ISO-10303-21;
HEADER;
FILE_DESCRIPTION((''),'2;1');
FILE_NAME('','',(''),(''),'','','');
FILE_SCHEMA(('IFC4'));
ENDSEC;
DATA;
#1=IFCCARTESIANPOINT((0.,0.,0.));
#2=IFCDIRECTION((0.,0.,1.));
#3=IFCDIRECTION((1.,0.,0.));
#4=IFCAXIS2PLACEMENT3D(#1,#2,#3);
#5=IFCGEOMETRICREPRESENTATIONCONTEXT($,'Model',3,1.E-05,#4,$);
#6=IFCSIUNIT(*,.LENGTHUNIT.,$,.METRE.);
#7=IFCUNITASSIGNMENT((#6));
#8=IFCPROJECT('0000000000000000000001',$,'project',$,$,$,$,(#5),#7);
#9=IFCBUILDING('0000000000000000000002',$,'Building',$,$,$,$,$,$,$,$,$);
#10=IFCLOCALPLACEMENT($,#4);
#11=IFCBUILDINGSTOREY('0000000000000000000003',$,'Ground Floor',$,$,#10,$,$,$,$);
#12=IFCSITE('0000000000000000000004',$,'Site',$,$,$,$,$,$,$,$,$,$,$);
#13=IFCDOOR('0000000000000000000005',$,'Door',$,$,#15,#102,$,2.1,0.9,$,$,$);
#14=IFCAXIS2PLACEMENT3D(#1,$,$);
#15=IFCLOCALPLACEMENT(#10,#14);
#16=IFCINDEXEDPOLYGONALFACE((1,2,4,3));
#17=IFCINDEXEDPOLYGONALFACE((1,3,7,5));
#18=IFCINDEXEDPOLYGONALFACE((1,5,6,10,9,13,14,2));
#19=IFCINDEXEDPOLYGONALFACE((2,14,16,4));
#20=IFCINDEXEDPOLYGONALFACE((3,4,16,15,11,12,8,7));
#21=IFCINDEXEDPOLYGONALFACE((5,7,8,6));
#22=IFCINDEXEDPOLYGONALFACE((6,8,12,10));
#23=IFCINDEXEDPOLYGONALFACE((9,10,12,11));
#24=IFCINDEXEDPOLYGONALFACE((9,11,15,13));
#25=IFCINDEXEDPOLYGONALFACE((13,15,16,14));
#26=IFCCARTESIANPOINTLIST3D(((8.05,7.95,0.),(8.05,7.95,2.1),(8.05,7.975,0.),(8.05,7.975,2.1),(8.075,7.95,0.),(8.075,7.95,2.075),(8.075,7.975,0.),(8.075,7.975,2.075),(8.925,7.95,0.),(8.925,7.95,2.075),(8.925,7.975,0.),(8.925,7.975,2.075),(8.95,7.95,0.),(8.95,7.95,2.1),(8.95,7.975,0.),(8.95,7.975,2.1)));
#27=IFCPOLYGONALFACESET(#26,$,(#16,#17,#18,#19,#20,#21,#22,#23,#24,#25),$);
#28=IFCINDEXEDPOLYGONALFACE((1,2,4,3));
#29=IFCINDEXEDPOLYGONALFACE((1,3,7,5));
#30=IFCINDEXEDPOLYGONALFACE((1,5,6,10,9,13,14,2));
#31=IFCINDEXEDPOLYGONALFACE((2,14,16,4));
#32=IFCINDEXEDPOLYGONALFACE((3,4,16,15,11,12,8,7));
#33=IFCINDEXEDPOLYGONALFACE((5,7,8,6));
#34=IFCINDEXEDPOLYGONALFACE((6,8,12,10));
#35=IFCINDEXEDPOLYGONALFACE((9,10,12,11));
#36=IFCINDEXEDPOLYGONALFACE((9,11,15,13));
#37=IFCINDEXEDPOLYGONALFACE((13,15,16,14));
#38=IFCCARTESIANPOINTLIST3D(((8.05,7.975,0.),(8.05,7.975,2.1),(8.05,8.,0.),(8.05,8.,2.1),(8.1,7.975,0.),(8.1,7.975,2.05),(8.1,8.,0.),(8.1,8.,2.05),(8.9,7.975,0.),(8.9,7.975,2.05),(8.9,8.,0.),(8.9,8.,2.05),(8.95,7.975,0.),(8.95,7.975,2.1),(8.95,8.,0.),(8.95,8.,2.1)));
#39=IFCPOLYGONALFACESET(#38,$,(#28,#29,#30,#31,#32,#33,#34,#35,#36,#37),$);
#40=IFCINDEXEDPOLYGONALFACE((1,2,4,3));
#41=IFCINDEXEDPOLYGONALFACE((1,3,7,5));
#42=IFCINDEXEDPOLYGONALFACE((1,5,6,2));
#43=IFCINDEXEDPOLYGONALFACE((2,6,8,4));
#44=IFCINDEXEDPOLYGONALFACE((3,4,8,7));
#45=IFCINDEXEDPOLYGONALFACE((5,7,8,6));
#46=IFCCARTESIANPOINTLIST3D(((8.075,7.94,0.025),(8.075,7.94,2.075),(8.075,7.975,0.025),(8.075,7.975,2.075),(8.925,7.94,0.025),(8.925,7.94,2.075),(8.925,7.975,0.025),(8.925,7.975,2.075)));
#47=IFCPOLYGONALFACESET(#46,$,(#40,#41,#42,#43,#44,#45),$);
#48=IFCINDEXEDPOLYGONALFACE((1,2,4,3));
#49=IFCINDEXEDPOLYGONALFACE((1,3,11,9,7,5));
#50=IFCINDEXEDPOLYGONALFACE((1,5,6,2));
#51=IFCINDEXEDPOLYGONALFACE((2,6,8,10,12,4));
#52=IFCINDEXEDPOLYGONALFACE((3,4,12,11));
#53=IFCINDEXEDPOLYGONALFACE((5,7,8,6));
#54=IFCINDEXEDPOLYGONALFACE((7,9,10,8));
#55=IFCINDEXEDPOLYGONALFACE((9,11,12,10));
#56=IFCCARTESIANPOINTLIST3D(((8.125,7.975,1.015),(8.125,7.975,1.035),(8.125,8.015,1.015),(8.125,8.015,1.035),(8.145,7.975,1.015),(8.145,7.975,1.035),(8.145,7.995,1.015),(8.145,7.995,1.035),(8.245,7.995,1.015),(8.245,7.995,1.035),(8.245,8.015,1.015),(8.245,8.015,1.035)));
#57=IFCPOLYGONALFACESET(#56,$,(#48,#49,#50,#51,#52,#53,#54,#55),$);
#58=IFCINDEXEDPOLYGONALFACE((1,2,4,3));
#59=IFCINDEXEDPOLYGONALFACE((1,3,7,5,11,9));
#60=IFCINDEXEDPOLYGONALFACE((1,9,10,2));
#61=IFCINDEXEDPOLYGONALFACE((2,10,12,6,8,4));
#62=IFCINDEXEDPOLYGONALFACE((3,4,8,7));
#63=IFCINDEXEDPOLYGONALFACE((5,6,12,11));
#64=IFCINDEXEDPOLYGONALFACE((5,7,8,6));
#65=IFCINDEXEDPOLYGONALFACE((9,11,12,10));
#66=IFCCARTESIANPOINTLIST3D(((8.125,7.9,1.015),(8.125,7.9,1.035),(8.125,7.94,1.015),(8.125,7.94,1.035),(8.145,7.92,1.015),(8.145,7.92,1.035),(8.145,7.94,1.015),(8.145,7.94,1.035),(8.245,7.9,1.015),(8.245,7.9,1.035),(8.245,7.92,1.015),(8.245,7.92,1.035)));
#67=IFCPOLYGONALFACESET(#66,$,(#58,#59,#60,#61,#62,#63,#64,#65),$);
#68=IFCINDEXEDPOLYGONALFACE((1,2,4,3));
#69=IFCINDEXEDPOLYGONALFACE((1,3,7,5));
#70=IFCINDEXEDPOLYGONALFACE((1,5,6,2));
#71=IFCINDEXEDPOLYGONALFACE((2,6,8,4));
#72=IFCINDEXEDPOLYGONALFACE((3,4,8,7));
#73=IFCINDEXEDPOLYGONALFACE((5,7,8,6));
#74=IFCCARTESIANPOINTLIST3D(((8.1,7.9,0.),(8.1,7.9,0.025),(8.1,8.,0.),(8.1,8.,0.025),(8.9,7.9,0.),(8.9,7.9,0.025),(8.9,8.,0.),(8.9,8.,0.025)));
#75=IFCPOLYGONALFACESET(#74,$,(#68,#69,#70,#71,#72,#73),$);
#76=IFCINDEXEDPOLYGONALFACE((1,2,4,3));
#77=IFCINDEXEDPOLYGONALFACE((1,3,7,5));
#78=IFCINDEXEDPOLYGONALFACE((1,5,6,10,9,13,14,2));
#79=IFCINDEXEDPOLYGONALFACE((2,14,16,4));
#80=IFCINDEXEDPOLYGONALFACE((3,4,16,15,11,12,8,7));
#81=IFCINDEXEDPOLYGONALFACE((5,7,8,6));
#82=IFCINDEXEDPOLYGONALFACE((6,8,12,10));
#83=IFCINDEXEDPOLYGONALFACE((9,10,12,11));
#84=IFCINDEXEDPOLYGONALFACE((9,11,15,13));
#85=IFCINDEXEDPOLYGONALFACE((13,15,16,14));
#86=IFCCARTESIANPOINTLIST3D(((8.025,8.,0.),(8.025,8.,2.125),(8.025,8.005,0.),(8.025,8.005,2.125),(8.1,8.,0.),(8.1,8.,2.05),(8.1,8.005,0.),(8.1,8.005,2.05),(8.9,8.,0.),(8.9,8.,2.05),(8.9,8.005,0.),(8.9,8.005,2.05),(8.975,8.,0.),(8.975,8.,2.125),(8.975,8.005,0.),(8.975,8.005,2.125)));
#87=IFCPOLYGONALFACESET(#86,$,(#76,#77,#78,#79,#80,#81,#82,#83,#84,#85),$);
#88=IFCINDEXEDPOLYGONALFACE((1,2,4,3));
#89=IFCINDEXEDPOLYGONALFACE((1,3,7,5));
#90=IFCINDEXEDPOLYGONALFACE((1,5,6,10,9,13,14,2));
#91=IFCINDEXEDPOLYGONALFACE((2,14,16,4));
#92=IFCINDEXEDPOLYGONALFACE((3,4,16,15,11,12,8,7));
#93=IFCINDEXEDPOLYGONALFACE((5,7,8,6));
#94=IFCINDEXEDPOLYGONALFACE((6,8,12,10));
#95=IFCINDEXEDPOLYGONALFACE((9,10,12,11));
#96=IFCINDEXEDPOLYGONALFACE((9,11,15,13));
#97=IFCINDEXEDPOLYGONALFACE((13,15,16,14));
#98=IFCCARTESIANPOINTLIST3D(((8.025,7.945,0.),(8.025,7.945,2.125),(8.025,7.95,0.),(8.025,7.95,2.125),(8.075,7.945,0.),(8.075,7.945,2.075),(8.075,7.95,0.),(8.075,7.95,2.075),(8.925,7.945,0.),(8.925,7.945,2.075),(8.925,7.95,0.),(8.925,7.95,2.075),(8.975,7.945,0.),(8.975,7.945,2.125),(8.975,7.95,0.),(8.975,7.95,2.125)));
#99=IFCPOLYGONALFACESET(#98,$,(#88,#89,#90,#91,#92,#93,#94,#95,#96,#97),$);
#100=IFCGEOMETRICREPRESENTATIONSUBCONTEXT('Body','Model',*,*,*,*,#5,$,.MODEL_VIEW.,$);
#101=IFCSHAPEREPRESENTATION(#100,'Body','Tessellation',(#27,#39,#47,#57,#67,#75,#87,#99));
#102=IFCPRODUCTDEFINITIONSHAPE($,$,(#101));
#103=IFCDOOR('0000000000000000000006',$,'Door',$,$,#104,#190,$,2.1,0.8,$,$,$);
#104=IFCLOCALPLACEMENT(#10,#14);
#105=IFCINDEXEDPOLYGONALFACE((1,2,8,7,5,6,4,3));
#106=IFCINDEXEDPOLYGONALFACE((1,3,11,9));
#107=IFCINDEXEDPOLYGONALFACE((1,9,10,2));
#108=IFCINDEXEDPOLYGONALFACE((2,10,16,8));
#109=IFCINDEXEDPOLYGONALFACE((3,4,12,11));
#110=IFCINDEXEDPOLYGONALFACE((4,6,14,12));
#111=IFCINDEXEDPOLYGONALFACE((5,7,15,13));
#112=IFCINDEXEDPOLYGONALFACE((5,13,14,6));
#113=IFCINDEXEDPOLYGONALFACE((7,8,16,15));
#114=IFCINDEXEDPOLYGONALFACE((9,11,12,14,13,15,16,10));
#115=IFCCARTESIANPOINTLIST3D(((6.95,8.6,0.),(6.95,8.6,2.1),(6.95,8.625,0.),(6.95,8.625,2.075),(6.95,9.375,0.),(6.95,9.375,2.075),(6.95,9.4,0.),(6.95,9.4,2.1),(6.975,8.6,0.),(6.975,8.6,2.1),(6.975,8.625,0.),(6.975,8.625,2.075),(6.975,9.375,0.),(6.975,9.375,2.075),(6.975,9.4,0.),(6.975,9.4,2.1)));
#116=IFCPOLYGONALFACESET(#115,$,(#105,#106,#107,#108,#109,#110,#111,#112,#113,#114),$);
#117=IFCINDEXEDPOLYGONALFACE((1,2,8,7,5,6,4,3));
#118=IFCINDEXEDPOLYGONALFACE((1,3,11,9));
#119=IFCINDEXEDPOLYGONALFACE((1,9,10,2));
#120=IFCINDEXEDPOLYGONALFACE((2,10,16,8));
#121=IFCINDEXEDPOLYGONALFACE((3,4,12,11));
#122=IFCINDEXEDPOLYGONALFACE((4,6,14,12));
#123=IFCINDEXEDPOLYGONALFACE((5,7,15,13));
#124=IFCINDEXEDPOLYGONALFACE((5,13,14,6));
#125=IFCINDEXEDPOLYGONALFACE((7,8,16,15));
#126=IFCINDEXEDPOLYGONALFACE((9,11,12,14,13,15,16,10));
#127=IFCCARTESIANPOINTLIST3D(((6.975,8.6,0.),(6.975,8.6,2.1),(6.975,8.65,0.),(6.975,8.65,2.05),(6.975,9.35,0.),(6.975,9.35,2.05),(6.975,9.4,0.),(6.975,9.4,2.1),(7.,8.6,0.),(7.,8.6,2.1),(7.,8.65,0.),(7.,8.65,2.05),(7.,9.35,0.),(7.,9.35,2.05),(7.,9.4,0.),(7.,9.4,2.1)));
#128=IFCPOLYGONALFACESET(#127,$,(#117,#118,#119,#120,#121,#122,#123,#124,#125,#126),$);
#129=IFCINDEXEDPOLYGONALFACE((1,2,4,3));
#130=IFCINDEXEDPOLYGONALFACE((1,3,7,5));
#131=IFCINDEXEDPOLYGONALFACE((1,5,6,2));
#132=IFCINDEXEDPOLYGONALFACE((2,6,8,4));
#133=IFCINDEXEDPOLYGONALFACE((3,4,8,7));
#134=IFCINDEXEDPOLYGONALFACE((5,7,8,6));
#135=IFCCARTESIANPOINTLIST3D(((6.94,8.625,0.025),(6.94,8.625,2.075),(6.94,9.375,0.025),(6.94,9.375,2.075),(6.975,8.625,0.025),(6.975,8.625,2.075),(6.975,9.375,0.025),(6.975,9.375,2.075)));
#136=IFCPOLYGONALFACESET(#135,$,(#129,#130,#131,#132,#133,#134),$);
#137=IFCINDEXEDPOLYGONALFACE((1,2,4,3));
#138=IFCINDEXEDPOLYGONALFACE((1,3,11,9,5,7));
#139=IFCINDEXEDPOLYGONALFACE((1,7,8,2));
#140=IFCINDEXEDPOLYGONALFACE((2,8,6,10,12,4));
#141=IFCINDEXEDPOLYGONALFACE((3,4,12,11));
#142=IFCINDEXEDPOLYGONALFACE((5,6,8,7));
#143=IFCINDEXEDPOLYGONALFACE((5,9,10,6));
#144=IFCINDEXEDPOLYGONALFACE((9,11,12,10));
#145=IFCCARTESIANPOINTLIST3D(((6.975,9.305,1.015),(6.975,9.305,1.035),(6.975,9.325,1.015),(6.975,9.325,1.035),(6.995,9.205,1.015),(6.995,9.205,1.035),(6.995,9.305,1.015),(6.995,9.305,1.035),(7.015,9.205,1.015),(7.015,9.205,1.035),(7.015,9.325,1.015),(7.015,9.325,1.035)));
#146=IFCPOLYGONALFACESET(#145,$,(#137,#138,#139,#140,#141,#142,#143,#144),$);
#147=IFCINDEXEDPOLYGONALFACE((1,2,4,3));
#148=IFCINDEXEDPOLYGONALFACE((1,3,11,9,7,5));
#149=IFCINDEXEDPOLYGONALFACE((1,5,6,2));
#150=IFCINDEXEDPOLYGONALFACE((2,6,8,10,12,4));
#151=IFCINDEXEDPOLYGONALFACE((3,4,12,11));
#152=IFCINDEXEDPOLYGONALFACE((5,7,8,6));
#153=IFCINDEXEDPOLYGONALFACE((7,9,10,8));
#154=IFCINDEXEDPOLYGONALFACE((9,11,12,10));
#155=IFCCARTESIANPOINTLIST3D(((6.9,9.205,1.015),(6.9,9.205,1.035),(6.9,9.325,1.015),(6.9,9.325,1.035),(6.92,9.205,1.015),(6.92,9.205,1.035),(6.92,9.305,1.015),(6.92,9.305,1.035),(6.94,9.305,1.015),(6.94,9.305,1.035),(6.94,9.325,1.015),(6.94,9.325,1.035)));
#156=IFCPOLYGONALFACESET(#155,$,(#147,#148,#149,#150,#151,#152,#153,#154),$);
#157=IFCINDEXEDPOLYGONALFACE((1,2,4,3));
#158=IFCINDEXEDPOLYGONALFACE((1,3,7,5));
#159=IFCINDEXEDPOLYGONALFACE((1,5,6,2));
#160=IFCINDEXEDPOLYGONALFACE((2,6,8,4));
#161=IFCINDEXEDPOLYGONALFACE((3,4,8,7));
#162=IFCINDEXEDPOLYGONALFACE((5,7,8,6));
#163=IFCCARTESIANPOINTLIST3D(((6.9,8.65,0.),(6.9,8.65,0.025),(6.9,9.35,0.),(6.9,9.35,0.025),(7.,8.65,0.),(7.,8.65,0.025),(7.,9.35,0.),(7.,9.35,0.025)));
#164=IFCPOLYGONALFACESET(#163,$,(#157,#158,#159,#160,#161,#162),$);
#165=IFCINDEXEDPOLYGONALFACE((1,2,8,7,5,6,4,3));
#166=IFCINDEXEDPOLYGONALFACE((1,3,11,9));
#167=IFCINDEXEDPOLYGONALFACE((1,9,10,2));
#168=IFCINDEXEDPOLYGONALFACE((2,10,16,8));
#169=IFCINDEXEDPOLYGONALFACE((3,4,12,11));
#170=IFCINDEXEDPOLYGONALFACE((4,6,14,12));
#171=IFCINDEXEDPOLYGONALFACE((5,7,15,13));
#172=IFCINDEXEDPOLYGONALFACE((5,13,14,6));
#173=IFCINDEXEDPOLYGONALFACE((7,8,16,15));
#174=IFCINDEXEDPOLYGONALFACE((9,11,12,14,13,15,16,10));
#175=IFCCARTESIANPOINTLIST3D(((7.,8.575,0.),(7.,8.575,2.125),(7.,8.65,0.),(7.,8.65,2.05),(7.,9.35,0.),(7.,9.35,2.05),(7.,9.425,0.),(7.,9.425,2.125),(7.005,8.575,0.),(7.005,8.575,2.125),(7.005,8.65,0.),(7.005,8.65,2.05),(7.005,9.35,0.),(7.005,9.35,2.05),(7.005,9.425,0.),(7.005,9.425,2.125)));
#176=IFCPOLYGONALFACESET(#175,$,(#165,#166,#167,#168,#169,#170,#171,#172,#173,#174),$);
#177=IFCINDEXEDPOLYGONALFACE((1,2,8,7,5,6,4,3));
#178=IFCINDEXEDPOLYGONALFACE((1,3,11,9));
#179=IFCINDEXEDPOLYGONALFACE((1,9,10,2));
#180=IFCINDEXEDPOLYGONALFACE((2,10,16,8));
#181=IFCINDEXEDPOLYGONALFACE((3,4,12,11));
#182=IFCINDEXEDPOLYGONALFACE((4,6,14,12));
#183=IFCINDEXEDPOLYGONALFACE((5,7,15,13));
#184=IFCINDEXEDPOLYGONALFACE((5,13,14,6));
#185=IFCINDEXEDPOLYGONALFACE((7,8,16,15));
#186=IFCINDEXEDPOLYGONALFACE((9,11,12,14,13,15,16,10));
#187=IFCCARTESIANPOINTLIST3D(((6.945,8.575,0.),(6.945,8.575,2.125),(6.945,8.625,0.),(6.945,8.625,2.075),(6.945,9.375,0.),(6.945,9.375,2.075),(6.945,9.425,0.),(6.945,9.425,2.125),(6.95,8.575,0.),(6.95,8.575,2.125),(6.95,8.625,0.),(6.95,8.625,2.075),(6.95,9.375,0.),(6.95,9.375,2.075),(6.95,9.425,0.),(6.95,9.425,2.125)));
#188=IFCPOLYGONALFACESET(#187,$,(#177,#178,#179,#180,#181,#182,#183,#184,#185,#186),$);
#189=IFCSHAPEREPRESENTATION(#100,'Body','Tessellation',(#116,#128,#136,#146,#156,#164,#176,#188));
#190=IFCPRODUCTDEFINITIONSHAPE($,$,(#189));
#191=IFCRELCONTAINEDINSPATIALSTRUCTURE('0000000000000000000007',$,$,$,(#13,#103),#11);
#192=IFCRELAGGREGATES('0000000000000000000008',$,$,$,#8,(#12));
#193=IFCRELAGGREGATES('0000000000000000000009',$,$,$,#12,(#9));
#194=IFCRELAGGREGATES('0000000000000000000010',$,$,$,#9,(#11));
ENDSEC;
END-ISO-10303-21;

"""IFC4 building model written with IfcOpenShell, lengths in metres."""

from ifc_helpers import new_model, si_unit, frame, origin_with_axes, place, context, subcontext, project, spatial, line, indexed_curve, outline, extrude, element, save


model = new_model("IFC4")

# Units and contexts
model_context = context("Model", 3, precision=1e-05, world=origin_with_axes())
body_context = subcontext(model_context, "Body", "Model", "MODEL_VIEW")
ifc_project = project(units=[si_unit("LENGTHUNIT", "METRE")], contexts=[model_context])

# Site, building, storey
site = spatial("IfcSite", under=ifc_project, Name="Site")
building = spatial("IfcBuilding", under=site, Name="Building")
storey_placement = place(None, origin_with_axes())
storey = spatial("IfcBuildingStorey", under=building, at=storey_placement, Name="Ground Floor")

# Doors
door_1_placement = place(storey_placement, frame((8.95, 8.0, 0.0), z_axis=(0.0, 0.0, 1.0), x_axis=(-1.0, 0.0, 0.0)))
element("IfcDoor", 1, at=door_1_placement, inside=storey, Name="Door", OverallHeight=2.1, OverallWidth=0.9, context=body_context, shape_type="SweptSolid", body=[
    extrude(outline(indexed_curve([(0.0, 0.0), (0.0, 2.1), (0.9, 2.1), (0.9, 0.0), (0.875, 0.0), (0.875, 2.075), (0.025, 2.075), (0.025, 0.0)], segments=[line(1, 2, 3, 4, 5, 6, 7, 8, 1)])), frame((0.0, 0.025, 0.0), z_axis=(0.0, -1.0, 0.0), x_axis=(1.0, 0.0, 0.0)), (0.0, 0.0, -1.0), 0.025),
    extrude(outline(indexed_curve([(0.0, 0.0), (0.0, 2.1), (0.9, 2.1), (0.9, 0.0), (0.85, 0.0), (0.85, 2.05), (0.05, 2.05), (0.05, 0.0)], segments=[line(1, 2, 3, 4, 5, 6, 7, 8, 1)])), frame((0.0, 0.0, 0.0), z_axis=(0.0, -1.0, 0.0), x_axis=(1.0, 0.0, 0.0)), (0.0, 0.0, -1.0), 0.025),
    extrude(outline(indexed_curve([(0.0, 0.0), (0.85, 0.0), (0.85, 0.035), (0.0, 0.035)], segments=[line(1, 2, 3, 4, 1)])), frame((0.025, 0.025, 0.025), z_axis=(0.0, 0.0, 1.0), x_axis=(1.0, 0.0, 0.0)), (0.0, 0.0, 1.0), 2.05),
    extrude(outline(indexed_curve([(0.0, 0.0), (0.0, -0.04), (-0.12, -0.04), (-0.12, -0.02), (-0.02, -0.02), (-0.02, 0.0)], segments=[line(1, 2, 3, 4, 5, 6, 1)])), frame((0.825, 0.025, 1.015), z_axis=(0.0, 0.0, 1.0), x_axis=(1.0, 0.0, 0.0)), (0.0, 0.0, 1.0), 0.02),
    extrude(outline(indexed_curve([(0.0, 0.0), (0.0, 0.04), (-0.12, 0.04), (-0.12, 0.02), (-0.02, 0.02), (-0.02, 0.0)], segments=[line(1, 2, 3, 4, 5, 6, 1)])), frame((0.825, 0.06, 1.015), z_axis=(0.0, 0.0, 1.0), x_axis=(1.0, 0.0, 0.0)), (0.0, 0.0, 1.0), 0.02),
    extrude(outline(indexed_curve([(0.0, 0.0), (0.8, 0.0), (0.8, 0.1), (0.0, 0.1)], segments=[line(1, 2, 3, 4, 1)])), frame((0.05, 0.0, 0.0), z_axis=(0.0, 0.0, 1.0), x_axis=(1.0, 0.0, 0.0)), (0.0, 0.0, 1.0), 0.025),
    extrude(outline(indexed_curve([(0.0, 0.0), (0.0, 2.125), (0.95, 2.125), (0.95, 0.0), (0.875, 0.0), (0.875, 2.05), (0.075, 2.05), (0.075, 0.0)], segments=[line(1, 2, 3, 4, 5, 6, 7, 8, 1)])), frame((-0.025, -0.005, 0.0), z_axis=(0.0, -1.0, 0.0), x_axis=(1.0, 0.0, 0.0)), (0.0, 0.0, -1.0), 0.005),
    extrude(outline(indexed_curve([(0.0, 0.0), (0.0, 2.125), (0.95, 2.125), (0.95, 0.0), (0.9, 0.0), (0.9, 2.075), (0.05, 2.075), (0.05, 0.0)], segments=[line(1, 2, 3, 4, 5, 6, 7, 8, 1)])), frame((-0.025, 0.05, 0.0), z_axis=(0.0, -1.0, 0.0), x_axis=(1.0, 0.0, 0.0)), (0.0, 0.0, -1.0), 0.005),
])
door_2_placement = place(storey_placement, frame((7.0, 8.6, 0.0), z_axis=(0.0, 0.0, 1.0), x_axis=(0.0, 1.0, 0.0)))
element("IfcDoor", 2, at=door_2_placement, inside=storey, Name="Door", OverallHeight=2.1, OverallWidth=0.8, context=body_context, shape_type="SweptSolid", body=[
    extrude(outline(indexed_curve([(0.0, 0.0), (0.0, 2.1), (0.8, 2.1), (0.8, 0.0), (0.775, 0.0), (0.775, 2.075), (0.025, 2.075), (0.025, 0.0)], segments=[line(1, 2, 3, 4, 5, 6, 7, 8, 1)])), frame((0.0, 0.025, 0.0), z_axis=(0.0, -1.0, 0.0), x_axis=(1.0, 0.0, 0.0)), (0.0, 0.0, -1.0), 0.025),
    extrude(outline(indexed_curve([(0.0, 0.0), (0.0, 2.1), (0.8, 2.1), (0.8, 0.0), (0.75, 0.0), (0.75, 2.05), (0.05, 2.05), (0.05, 0.0)], segments=[line(1, 2, 3, 4, 5, 6, 7, 8, 1)])), frame((0.0, 0.0, 0.0), z_axis=(0.0, -1.0, 0.0), x_axis=(1.0, 0.0, 0.0)), (0.0, 0.0, -1.0), 0.025),
    extrude(outline(indexed_curve([(0.0, 0.0), (0.75, 0.0), (0.75, 0.035), (0.0, 0.035)], segments=[line(1, 2, 3, 4, 1)])), frame((0.025, 0.025, 0.025), z_axis=(0.0, 0.0, 1.0), x_axis=(1.0, 0.0, 0.0)), (0.0, 0.0, 1.0), 2.05),
    extrude(outline(indexed_curve([(0.0, 0.0), (0.0, -0.04), (-0.12, -0.04), (-0.12, -0.02), (-0.02, -0.02), (-0.02, 0.0)], segments=[line(1, 2, 3, 4, 5, 6, 1)])), frame((0.725, 0.025, 1.015), z_axis=(0.0, 0.0, 1.0), x_axis=(1.0, 0.0, 0.0)), (0.0, 0.0, 1.0), 0.02),
    extrude(outline(indexed_curve([(0.0, 0.0), (0.0, 0.04), (-0.12, 0.04), (-0.12, 0.02), (-0.02, 0.02), (-0.02, 0.0)], segments=[line(1, 2, 3, 4, 5, 6, 1)])), frame((0.725, 0.06, 1.015), z_axis=(0.0, 0.0, 1.0), x_axis=(1.0, 0.0, 0.0)), (0.0, 0.0, 1.0), 0.02),
    extrude(outline(indexed_curve([(0.0, 0.0), (0.7, 0.0), (0.7, 0.1), (0.0, 0.1)], segments=[line(1, 2, 3, 4, 1)])), frame((0.05, 0.0, 0.0), z_axis=(0.0, 0.0, 1.0), x_axis=(1.0, 0.0, 0.0)), (0.0, 0.0, 1.0), 0.025),
    extrude(outline(indexed_curve([(0.0, 0.0), (0.0, 2.125), (0.85, 2.125), (0.85, 0.0), (0.775, 0.0), (0.775, 2.05), (0.075, 2.05), (0.075, 0.0)], segments=[line(1, 2, 3, 4, 5, 6, 7, 8, 1)])), frame((-0.025, -0.005, 0.0), z_axis=(0.0, -1.0, 0.0), x_axis=(1.0, 0.0, 0.0)), (0.0, 0.0, -1.0), 0.005),
    extrude(outline(indexed_curve([(0.0, 0.0), (0.0, 2.125), (0.85, 2.125), (0.85, 0.0), (0.8, 0.0), (0.8, 2.075), (0.05, 2.075), (0.05, 0.0)], segments=[line(1, 2, 3, 4, 5, 6, 7, 8, 1)])), frame((-0.025, 0.05, 0.0), z_axis=(0.0, -1.0, 0.0), x_axis=(1.0, 0.0, 0.0)), (0.0, 0.0, -1.0), 0.005),
])

save(model, "model.ifc")
